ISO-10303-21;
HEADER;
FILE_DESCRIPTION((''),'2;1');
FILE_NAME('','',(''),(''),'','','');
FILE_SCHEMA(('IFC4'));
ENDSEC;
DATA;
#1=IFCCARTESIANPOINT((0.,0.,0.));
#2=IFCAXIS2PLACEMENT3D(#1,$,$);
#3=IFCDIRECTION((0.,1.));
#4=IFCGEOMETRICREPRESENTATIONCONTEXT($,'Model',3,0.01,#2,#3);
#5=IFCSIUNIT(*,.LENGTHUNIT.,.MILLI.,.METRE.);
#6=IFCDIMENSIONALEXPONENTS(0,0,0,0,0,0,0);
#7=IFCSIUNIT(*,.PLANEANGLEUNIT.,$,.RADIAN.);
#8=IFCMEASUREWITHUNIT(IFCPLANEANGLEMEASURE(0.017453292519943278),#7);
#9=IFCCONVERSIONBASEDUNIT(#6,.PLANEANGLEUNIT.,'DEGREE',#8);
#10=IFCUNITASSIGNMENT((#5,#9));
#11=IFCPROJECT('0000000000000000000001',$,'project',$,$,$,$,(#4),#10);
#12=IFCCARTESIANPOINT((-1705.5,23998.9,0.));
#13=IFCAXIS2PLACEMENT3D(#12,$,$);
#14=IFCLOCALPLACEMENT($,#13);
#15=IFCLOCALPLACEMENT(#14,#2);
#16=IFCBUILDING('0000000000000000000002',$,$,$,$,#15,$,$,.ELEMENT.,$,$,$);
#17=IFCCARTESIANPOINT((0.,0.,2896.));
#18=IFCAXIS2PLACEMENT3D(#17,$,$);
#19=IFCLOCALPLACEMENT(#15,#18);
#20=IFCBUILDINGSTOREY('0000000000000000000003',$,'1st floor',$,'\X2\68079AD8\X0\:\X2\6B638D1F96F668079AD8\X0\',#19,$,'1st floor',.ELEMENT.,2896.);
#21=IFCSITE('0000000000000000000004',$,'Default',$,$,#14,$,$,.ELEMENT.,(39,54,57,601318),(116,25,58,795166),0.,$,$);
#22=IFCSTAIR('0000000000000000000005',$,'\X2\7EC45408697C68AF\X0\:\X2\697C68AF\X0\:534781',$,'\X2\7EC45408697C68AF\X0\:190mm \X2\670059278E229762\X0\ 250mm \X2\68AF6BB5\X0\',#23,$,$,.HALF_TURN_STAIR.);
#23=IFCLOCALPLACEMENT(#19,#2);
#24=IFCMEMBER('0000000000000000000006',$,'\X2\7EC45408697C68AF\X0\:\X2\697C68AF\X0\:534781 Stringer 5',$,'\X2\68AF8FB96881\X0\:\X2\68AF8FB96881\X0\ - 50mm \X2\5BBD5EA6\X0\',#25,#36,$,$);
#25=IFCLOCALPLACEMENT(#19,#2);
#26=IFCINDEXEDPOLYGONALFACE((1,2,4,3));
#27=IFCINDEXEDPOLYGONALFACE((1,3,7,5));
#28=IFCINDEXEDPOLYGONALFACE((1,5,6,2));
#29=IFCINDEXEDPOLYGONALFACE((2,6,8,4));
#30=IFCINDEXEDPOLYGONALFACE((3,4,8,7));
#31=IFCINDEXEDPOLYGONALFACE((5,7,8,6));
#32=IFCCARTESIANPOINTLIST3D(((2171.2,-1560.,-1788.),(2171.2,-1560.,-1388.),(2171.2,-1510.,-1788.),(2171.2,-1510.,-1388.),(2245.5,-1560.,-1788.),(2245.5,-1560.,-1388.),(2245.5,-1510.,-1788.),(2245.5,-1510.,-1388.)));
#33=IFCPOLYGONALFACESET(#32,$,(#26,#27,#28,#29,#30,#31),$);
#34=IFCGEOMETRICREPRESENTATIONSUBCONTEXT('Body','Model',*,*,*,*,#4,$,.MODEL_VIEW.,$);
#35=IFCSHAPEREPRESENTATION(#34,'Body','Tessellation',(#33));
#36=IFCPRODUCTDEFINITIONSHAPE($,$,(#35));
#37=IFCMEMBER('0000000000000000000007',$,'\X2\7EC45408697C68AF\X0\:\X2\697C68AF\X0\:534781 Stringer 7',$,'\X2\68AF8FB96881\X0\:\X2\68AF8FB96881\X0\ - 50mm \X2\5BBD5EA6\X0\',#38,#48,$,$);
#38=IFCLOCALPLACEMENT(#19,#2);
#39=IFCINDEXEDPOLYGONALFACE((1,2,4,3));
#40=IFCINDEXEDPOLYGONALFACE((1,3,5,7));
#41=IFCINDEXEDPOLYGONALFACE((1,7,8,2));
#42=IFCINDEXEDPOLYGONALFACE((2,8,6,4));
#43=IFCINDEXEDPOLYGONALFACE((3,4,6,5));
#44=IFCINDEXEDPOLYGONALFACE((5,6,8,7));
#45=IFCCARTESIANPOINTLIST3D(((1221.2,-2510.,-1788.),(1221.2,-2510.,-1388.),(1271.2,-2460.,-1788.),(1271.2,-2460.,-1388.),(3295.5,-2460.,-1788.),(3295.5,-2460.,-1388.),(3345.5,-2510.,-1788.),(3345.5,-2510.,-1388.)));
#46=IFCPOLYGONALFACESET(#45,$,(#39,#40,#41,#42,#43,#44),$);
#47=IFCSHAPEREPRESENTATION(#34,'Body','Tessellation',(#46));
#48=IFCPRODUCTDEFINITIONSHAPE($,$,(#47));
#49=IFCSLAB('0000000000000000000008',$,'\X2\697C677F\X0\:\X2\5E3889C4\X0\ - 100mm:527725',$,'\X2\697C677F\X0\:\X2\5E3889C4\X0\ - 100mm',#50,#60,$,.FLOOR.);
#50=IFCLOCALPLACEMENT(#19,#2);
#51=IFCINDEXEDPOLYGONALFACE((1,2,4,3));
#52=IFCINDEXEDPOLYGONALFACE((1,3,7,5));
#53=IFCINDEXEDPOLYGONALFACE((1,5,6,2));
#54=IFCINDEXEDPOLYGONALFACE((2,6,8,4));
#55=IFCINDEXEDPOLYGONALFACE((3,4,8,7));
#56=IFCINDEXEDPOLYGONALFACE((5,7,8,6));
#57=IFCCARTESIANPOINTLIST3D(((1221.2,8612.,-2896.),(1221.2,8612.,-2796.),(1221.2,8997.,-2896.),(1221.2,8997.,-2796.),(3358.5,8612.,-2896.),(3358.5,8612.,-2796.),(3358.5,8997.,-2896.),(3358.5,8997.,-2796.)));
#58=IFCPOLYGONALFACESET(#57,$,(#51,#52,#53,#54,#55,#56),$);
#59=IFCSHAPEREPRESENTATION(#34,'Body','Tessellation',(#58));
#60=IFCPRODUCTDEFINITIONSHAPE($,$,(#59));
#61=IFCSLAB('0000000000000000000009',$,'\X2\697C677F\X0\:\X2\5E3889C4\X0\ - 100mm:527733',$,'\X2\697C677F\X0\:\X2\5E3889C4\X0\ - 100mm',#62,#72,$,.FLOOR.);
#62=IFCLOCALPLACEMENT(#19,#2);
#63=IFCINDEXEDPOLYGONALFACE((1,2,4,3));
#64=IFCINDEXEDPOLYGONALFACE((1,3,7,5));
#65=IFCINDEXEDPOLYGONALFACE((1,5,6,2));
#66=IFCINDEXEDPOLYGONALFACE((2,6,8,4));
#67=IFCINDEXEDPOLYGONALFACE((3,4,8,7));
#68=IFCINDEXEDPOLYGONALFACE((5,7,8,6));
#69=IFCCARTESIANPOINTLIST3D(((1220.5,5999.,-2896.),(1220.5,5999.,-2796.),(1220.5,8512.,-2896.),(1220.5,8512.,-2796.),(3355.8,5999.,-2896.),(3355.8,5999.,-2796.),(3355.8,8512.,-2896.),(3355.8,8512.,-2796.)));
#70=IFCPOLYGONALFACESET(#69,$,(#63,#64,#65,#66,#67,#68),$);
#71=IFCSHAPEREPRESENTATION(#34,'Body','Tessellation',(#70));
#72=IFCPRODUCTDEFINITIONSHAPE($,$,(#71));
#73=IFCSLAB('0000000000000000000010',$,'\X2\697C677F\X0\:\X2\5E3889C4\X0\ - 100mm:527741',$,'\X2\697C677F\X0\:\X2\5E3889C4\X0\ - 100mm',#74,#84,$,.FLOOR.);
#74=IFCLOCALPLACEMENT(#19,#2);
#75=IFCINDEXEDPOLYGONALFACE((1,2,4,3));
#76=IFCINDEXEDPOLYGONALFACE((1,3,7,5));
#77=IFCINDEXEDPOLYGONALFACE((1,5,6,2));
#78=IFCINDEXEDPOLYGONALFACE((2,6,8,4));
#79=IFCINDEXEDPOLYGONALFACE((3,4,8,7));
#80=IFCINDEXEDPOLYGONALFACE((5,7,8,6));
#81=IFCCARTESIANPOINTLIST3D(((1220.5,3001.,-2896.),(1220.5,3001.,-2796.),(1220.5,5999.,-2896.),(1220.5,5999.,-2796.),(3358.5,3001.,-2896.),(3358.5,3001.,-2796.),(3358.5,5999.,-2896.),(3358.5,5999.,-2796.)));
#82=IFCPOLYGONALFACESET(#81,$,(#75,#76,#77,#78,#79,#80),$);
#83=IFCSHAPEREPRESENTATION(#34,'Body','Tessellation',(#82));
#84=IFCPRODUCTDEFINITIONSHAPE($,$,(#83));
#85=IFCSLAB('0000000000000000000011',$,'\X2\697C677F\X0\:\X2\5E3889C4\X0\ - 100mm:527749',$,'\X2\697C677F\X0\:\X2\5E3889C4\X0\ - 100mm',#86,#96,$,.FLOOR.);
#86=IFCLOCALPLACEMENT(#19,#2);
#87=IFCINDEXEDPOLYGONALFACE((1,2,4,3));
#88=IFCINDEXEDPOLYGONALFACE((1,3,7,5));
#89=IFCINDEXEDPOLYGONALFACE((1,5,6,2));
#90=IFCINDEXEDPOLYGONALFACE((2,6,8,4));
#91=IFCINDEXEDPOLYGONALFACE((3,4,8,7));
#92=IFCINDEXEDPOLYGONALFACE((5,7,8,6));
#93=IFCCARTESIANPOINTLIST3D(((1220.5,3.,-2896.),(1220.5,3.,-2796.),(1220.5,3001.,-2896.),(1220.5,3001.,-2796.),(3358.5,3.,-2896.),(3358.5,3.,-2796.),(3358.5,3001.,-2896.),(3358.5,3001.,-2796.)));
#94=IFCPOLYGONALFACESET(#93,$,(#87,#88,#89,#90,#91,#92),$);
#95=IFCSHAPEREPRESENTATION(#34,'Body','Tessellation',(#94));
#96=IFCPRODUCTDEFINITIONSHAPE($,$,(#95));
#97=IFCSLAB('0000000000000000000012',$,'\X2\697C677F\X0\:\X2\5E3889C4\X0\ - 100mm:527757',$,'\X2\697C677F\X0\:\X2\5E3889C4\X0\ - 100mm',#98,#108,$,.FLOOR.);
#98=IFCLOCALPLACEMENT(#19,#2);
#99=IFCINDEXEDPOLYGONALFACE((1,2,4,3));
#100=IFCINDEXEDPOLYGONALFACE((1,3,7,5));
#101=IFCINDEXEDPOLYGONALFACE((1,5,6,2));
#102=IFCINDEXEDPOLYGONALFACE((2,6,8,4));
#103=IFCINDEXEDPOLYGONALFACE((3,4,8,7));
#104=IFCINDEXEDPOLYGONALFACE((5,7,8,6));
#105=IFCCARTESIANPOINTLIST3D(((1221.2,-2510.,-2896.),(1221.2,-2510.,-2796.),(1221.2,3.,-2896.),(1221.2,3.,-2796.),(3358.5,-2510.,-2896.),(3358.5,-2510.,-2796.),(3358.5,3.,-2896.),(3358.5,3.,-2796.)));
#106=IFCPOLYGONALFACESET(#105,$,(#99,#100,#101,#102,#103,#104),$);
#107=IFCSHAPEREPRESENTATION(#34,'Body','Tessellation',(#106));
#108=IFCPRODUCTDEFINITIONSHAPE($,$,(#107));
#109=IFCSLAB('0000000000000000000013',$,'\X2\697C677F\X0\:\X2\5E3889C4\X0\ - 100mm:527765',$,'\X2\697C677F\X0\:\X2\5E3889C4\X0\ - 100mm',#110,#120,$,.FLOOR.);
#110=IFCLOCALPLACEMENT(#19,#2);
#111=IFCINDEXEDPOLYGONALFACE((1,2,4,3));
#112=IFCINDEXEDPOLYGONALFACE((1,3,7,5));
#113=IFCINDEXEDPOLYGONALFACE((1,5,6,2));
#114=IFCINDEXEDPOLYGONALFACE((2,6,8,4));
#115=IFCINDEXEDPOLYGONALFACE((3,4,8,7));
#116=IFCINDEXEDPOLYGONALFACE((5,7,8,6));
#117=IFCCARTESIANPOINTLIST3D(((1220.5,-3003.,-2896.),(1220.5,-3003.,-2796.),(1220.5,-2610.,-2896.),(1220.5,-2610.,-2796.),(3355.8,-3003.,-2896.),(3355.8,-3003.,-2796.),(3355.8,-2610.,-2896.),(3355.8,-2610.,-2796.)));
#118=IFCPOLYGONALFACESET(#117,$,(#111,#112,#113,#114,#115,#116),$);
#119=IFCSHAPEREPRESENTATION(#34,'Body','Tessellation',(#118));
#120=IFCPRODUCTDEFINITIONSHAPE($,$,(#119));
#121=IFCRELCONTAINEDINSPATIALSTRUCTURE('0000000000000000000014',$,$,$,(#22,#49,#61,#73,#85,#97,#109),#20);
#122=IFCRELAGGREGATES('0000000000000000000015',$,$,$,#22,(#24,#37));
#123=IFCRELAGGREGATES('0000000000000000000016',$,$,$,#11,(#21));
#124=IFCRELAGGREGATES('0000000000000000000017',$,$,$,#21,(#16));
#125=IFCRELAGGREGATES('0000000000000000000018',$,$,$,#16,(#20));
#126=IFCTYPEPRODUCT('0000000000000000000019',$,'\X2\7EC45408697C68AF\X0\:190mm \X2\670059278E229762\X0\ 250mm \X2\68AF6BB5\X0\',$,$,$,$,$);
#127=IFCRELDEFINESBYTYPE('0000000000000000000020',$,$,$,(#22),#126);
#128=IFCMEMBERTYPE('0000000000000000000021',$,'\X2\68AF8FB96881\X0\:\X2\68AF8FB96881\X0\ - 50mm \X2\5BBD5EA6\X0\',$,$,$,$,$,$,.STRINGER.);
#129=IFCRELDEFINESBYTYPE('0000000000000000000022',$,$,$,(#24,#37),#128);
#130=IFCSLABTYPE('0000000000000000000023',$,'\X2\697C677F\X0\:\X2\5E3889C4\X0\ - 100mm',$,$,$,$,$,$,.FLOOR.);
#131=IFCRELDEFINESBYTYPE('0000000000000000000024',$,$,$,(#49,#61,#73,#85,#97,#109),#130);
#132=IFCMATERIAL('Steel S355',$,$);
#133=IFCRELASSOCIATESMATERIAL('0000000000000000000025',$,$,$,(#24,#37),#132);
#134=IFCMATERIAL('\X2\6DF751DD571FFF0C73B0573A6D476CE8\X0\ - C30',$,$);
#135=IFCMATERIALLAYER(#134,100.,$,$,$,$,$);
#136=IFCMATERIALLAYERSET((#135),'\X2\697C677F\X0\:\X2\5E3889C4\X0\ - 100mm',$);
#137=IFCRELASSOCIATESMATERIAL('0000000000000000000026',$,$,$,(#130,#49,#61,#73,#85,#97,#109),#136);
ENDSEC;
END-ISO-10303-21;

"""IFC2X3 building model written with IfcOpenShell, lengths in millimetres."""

from ifc_helpers import new_model, entity, si_unit, converted_unit, direction, frame, frame_2d, origin, origin_2d_with_axis, place, context, subcontext, project, spatial, polyline, rectangle, outline, extrude, material, layer, layer_set, layer_usage, type_object, element, aggregate, save


model = new_model("IFC2X3")

# Units and contexts
model_context = context("Model", 3, precision=0.01, world=origin(), true_north=direction((0.0, 1.0)))
body_context = subcontext(model_context, "Body", "Model", "MODEL_VIEW")
ifc_project = project(units=[si_unit("LENGTHUNIT", "METRE", prefix="MILLI"), converted_unit("PLANEANGLEUNIT", "DEGREE", entity("IfcPlaneAngleMeasure", 0.017453292519943278), si_unit("PLANEANGLEUNIT", "RADIAN"), dimensions=[0, 0, 0, 0, 0, 0, 0])], contexts=[model_context])

# Site, building, storey
site_placement = place(None, frame((-1705.5, 23998.9, 0.0)))
site = spatial("IfcSite", under=ifc_project, at=site_placement, Name="Default", CompositionType="ELEMENT", RefLatitude=(39, 54, 57, 601318), RefLongitude=(116, 25, 58, 795166), RefElevation=0.0)
building_placement = place(site_placement, origin())
building = spatial("IfcBuilding", under=site, at=building_placement, CompositionType="ELEMENT")
storey_placement = place(building_placement, frame((0.0, 0.0, 2896.0)))
storey = spatial("IfcBuildingStorey", under=building, at=storey_placement, Name="1st floor", ObjectType="标高:正负零标高", LongName="1st floor", CompositionType="ELEMENT", Elevation=2896.0)

# Shared definitions
ifc_material_1 = material(Name="Steel S355")

# Stair, members
type_product = type_object("IfcTypeProduct", Name="组合楼梯:190mm 最大踢面 250mm 梯段")
stair_placement = place(storey_placement, origin())
stair = element("IfcStair", 1, at=stair_placement, inside=storey, type_object=type_product, Name="组合楼梯:楼梯:534781", ObjectType="组合楼梯:190mm 最大踢面 250mm 梯段", ShapeType="HALF_TURN_STAIR")
member_type_1 = type_object("IfcMemberType", Name="梯边梁:梯边梁 - 50mm 宽度", PredefinedType="STRINGER")
member_1_placement = place(stair_placement, origin())
member_1 = element("IfcMember", 2, at=member_1_placement, type_object=member_type_1, material=ifc_material_1, Name="组合楼梯:楼梯:534781 Stringer 5", ObjectType="梯边梁:梯边梁 - 50mm 宽度", context=body_context, shape_type="SweptSolid", body=[
    extrude(rectangle(XDim=74.3, YDim=50.0, at=frame_2d((0.0, 0.0), x_axis=(1.0, 0.0))), frame((2208.4, -1535.0, -1788.0), z_axis=(0.0, 0.0, 1.0), x_axis=(-1.0, 0.0, 0.0)), (0.0, 0.0, 1.0), 400.0),
])
member_2_placement = place(stair_placement, origin())
member_2 = element("IfcMember", 3, at=member_2_placement, type_object=member_type_1, material=ifc_material_1, Name="组合楼梯:楼梯:534781 Stringer 7", ObjectType="梯边梁:梯边梁 - 50mm 宽度", context=body_context, shape_type="SweptSolid", body=[
    extrude(outline(polyline([(-1062.2, -25.0), (1062.2, -25.0), (1012.2, 25.0), (-1012.2, 25.0), (-1062.2, -25.0)])), frame((2283.4, -2485.0, -1788.0)), (0.0, 0.0, 1.0), 400.0),
])

# Slabs
ifc_material_2 = material(Name="混凝土，现场浇注 - C30")
ifc_layer_1 = layer(ifc_material_2, 100.0)
ifc_layer_set_1 = layer_set([ifc_layer_1], Name="楼板:常规 - 100mm")
ifc_layer_usage_1 = layer_usage(ifc_layer_set_1, "AXIS3", "POSITIVE", 0.0)
slab_type_1 = type_object("IfcSlabType", Name="楼板:常规 - 100mm", PredefinedType="FLOOR", material=ifc_layer_set_1)
slab_1_placement = place(storey_placement, origin())
element("IfcSlab", 4, at=slab_1_placement, inside=storey, type_object=slab_type_1, material=ifc_layer_usage_1, Name="楼板:常规 - 100mm:527725", ObjectType="楼板:常规 - 100mm", PredefinedType="FLOOR", context=body_context, shape_type="SweptSolid", body=[
    extrude(rectangle(XDim=385.0, YDim=2137.3, at=origin_2d_with_axis()), frame((2289.9, 8804.5, -2796.0), z_axis=(0.0, 0.0, -1.0), x_axis=(0.0, 1.0, 0.0)), (0.0, 0.0, 1.0), 100.0),
])
ifc_layer_usage_2 = layer_usage(ifc_layer_set_1, "AXIS3", "POSITIVE", 0.0)
slab_2_placement = place(storey_placement, origin())
element("IfcSlab", 5, at=slab_2_placement, inside=storey, type_object=slab_type_1, material=ifc_layer_usage_2, Name="楼板:常规 - 100mm:527733", ObjectType="楼板:常规 - 100mm", PredefinedType="FLOOR", context=body_context, shape_type="SweptSolid", body=[
    extrude(rectangle(XDim=2513.0, YDim=2135.3, at=origin_2d_with_axis()), frame((2288.2, 7255.5, -2796.0), z_axis=(0.0, 0.0, -1.0), x_axis=(0.0, 1.0, 0.0)), (0.0, 0.0, 1.0), 100.0),
])
ifc_layer_usage_3 = layer_usage(ifc_layer_set_1, "AXIS3", "POSITIVE", 0.0)
slab_3_placement = place(storey_placement, origin())
element("IfcSlab", 6, at=slab_3_placement, inside=storey, type_object=slab_type_1, material=ifc_layer_usage_3, Name="楼板:常规 - 100mm:527741", ObjectType="楼板:常规 - 100mm", PredefinedType="FLOOR", context=body_context, shape_type="SweptSolid", body=[
    extrude(rectangle(XDim=2998.0, YDim=2138.0, at=origin_2d_with_axis()), frame((2289.5, 4500.0, -2796.0), z_axis=(0.0, 0.0, -1.0), x_axis=(0.0, 1.0, 0.0)), (0.0, 0.0, 1.0), 100.0),
])
ifc_layer_usage_4 = layer_usage(ifc_layer_set_1, "AXIS3", "POSITIVE", 0.0)
slab_4_placement = place(storey_placement, origin())
element("IfcSlab", 7, at=slab_4_placement, inside=storey, type_object=slab_type_1, material=ifc_layer_usage_4, Name="楼板:常规 - 100mm:527749", ObjectType="楼板:常规 - 100mm", PredefinedType="FLOOR", context=body_context, shape_type="SweptSolid", body=[
    extrude(rectangle(XDim=2998.0, YDim=2138.0, at=frame_2d((0.0, 0.0), x_axis=(1.0, 0.0))), frame((2289.5, 1502.0, -2796.0), z_axis=(0.0, 0.0, -1.0), x_axis=(0.0, 1.0, 0.0)), (0.0, 0.0, 1.0), 100.0),
])
ifc_layer_usage_5 = layer_usage(ifc_layer_set_1, "AXIS3", "POSITIVE", 0.0)
slab_5_placement = place(storey_placement, origin())
element("IfcSlab", 8, at=slab_5_placement, inside=storey, type_object=slab_type_1, material=ifc_layer_usage_5, Name="楼板:常规 - 100mm:527757", ObjectType="楼板:常规 - 100mm", PredefinedType="FLOOR", context=body_context, shape_type="SweptSolid", body=[
    extrude(rectangle(XDim=2513.0, YDim=2137.3, at=origin_2d_with_axis()), frame((2289.9, -1253.5, -2796.0), z_axis=(0.0, 0.0, -1.0), x_axis=(0.0, 1.0, 0.0)), (0.0, 0.0, 1.0), 100.0),
])
ifc_layer_usage_6 = layer_usage(ifc_layer_set_1, "AXIS3", "POSITIVE", 0.0)
slab_6_placement = place(storey_placement, origin())
element("IfcSlab", 9, at=slab_6_placement, inside=storey, type_object=slab_type_1, material=ifc_layer_usage_6, Name="楼板:常规 - 100mm:527765", ObjectType="楼板:常规 - 100mm", PredefinedType="FLOOR", context=body_context, shape_type="SweptSolid", body=[
    extrude(rectangle(XDim=393.0, YDim=2135.3, at=frame_2d((0.0, 0.0), x_axis=(1.0, 0.0))), frame((2288.2, -2806.5, -2796.0), z_axis=(0.0, 0.0, -1.0), x_axis=(0.0, 1.0, 0.0)), (0.0, 0.0, 1.0), 100.0),
])

aggregate(stair, [member_1, member_2])

save(model, "model.ifc")
